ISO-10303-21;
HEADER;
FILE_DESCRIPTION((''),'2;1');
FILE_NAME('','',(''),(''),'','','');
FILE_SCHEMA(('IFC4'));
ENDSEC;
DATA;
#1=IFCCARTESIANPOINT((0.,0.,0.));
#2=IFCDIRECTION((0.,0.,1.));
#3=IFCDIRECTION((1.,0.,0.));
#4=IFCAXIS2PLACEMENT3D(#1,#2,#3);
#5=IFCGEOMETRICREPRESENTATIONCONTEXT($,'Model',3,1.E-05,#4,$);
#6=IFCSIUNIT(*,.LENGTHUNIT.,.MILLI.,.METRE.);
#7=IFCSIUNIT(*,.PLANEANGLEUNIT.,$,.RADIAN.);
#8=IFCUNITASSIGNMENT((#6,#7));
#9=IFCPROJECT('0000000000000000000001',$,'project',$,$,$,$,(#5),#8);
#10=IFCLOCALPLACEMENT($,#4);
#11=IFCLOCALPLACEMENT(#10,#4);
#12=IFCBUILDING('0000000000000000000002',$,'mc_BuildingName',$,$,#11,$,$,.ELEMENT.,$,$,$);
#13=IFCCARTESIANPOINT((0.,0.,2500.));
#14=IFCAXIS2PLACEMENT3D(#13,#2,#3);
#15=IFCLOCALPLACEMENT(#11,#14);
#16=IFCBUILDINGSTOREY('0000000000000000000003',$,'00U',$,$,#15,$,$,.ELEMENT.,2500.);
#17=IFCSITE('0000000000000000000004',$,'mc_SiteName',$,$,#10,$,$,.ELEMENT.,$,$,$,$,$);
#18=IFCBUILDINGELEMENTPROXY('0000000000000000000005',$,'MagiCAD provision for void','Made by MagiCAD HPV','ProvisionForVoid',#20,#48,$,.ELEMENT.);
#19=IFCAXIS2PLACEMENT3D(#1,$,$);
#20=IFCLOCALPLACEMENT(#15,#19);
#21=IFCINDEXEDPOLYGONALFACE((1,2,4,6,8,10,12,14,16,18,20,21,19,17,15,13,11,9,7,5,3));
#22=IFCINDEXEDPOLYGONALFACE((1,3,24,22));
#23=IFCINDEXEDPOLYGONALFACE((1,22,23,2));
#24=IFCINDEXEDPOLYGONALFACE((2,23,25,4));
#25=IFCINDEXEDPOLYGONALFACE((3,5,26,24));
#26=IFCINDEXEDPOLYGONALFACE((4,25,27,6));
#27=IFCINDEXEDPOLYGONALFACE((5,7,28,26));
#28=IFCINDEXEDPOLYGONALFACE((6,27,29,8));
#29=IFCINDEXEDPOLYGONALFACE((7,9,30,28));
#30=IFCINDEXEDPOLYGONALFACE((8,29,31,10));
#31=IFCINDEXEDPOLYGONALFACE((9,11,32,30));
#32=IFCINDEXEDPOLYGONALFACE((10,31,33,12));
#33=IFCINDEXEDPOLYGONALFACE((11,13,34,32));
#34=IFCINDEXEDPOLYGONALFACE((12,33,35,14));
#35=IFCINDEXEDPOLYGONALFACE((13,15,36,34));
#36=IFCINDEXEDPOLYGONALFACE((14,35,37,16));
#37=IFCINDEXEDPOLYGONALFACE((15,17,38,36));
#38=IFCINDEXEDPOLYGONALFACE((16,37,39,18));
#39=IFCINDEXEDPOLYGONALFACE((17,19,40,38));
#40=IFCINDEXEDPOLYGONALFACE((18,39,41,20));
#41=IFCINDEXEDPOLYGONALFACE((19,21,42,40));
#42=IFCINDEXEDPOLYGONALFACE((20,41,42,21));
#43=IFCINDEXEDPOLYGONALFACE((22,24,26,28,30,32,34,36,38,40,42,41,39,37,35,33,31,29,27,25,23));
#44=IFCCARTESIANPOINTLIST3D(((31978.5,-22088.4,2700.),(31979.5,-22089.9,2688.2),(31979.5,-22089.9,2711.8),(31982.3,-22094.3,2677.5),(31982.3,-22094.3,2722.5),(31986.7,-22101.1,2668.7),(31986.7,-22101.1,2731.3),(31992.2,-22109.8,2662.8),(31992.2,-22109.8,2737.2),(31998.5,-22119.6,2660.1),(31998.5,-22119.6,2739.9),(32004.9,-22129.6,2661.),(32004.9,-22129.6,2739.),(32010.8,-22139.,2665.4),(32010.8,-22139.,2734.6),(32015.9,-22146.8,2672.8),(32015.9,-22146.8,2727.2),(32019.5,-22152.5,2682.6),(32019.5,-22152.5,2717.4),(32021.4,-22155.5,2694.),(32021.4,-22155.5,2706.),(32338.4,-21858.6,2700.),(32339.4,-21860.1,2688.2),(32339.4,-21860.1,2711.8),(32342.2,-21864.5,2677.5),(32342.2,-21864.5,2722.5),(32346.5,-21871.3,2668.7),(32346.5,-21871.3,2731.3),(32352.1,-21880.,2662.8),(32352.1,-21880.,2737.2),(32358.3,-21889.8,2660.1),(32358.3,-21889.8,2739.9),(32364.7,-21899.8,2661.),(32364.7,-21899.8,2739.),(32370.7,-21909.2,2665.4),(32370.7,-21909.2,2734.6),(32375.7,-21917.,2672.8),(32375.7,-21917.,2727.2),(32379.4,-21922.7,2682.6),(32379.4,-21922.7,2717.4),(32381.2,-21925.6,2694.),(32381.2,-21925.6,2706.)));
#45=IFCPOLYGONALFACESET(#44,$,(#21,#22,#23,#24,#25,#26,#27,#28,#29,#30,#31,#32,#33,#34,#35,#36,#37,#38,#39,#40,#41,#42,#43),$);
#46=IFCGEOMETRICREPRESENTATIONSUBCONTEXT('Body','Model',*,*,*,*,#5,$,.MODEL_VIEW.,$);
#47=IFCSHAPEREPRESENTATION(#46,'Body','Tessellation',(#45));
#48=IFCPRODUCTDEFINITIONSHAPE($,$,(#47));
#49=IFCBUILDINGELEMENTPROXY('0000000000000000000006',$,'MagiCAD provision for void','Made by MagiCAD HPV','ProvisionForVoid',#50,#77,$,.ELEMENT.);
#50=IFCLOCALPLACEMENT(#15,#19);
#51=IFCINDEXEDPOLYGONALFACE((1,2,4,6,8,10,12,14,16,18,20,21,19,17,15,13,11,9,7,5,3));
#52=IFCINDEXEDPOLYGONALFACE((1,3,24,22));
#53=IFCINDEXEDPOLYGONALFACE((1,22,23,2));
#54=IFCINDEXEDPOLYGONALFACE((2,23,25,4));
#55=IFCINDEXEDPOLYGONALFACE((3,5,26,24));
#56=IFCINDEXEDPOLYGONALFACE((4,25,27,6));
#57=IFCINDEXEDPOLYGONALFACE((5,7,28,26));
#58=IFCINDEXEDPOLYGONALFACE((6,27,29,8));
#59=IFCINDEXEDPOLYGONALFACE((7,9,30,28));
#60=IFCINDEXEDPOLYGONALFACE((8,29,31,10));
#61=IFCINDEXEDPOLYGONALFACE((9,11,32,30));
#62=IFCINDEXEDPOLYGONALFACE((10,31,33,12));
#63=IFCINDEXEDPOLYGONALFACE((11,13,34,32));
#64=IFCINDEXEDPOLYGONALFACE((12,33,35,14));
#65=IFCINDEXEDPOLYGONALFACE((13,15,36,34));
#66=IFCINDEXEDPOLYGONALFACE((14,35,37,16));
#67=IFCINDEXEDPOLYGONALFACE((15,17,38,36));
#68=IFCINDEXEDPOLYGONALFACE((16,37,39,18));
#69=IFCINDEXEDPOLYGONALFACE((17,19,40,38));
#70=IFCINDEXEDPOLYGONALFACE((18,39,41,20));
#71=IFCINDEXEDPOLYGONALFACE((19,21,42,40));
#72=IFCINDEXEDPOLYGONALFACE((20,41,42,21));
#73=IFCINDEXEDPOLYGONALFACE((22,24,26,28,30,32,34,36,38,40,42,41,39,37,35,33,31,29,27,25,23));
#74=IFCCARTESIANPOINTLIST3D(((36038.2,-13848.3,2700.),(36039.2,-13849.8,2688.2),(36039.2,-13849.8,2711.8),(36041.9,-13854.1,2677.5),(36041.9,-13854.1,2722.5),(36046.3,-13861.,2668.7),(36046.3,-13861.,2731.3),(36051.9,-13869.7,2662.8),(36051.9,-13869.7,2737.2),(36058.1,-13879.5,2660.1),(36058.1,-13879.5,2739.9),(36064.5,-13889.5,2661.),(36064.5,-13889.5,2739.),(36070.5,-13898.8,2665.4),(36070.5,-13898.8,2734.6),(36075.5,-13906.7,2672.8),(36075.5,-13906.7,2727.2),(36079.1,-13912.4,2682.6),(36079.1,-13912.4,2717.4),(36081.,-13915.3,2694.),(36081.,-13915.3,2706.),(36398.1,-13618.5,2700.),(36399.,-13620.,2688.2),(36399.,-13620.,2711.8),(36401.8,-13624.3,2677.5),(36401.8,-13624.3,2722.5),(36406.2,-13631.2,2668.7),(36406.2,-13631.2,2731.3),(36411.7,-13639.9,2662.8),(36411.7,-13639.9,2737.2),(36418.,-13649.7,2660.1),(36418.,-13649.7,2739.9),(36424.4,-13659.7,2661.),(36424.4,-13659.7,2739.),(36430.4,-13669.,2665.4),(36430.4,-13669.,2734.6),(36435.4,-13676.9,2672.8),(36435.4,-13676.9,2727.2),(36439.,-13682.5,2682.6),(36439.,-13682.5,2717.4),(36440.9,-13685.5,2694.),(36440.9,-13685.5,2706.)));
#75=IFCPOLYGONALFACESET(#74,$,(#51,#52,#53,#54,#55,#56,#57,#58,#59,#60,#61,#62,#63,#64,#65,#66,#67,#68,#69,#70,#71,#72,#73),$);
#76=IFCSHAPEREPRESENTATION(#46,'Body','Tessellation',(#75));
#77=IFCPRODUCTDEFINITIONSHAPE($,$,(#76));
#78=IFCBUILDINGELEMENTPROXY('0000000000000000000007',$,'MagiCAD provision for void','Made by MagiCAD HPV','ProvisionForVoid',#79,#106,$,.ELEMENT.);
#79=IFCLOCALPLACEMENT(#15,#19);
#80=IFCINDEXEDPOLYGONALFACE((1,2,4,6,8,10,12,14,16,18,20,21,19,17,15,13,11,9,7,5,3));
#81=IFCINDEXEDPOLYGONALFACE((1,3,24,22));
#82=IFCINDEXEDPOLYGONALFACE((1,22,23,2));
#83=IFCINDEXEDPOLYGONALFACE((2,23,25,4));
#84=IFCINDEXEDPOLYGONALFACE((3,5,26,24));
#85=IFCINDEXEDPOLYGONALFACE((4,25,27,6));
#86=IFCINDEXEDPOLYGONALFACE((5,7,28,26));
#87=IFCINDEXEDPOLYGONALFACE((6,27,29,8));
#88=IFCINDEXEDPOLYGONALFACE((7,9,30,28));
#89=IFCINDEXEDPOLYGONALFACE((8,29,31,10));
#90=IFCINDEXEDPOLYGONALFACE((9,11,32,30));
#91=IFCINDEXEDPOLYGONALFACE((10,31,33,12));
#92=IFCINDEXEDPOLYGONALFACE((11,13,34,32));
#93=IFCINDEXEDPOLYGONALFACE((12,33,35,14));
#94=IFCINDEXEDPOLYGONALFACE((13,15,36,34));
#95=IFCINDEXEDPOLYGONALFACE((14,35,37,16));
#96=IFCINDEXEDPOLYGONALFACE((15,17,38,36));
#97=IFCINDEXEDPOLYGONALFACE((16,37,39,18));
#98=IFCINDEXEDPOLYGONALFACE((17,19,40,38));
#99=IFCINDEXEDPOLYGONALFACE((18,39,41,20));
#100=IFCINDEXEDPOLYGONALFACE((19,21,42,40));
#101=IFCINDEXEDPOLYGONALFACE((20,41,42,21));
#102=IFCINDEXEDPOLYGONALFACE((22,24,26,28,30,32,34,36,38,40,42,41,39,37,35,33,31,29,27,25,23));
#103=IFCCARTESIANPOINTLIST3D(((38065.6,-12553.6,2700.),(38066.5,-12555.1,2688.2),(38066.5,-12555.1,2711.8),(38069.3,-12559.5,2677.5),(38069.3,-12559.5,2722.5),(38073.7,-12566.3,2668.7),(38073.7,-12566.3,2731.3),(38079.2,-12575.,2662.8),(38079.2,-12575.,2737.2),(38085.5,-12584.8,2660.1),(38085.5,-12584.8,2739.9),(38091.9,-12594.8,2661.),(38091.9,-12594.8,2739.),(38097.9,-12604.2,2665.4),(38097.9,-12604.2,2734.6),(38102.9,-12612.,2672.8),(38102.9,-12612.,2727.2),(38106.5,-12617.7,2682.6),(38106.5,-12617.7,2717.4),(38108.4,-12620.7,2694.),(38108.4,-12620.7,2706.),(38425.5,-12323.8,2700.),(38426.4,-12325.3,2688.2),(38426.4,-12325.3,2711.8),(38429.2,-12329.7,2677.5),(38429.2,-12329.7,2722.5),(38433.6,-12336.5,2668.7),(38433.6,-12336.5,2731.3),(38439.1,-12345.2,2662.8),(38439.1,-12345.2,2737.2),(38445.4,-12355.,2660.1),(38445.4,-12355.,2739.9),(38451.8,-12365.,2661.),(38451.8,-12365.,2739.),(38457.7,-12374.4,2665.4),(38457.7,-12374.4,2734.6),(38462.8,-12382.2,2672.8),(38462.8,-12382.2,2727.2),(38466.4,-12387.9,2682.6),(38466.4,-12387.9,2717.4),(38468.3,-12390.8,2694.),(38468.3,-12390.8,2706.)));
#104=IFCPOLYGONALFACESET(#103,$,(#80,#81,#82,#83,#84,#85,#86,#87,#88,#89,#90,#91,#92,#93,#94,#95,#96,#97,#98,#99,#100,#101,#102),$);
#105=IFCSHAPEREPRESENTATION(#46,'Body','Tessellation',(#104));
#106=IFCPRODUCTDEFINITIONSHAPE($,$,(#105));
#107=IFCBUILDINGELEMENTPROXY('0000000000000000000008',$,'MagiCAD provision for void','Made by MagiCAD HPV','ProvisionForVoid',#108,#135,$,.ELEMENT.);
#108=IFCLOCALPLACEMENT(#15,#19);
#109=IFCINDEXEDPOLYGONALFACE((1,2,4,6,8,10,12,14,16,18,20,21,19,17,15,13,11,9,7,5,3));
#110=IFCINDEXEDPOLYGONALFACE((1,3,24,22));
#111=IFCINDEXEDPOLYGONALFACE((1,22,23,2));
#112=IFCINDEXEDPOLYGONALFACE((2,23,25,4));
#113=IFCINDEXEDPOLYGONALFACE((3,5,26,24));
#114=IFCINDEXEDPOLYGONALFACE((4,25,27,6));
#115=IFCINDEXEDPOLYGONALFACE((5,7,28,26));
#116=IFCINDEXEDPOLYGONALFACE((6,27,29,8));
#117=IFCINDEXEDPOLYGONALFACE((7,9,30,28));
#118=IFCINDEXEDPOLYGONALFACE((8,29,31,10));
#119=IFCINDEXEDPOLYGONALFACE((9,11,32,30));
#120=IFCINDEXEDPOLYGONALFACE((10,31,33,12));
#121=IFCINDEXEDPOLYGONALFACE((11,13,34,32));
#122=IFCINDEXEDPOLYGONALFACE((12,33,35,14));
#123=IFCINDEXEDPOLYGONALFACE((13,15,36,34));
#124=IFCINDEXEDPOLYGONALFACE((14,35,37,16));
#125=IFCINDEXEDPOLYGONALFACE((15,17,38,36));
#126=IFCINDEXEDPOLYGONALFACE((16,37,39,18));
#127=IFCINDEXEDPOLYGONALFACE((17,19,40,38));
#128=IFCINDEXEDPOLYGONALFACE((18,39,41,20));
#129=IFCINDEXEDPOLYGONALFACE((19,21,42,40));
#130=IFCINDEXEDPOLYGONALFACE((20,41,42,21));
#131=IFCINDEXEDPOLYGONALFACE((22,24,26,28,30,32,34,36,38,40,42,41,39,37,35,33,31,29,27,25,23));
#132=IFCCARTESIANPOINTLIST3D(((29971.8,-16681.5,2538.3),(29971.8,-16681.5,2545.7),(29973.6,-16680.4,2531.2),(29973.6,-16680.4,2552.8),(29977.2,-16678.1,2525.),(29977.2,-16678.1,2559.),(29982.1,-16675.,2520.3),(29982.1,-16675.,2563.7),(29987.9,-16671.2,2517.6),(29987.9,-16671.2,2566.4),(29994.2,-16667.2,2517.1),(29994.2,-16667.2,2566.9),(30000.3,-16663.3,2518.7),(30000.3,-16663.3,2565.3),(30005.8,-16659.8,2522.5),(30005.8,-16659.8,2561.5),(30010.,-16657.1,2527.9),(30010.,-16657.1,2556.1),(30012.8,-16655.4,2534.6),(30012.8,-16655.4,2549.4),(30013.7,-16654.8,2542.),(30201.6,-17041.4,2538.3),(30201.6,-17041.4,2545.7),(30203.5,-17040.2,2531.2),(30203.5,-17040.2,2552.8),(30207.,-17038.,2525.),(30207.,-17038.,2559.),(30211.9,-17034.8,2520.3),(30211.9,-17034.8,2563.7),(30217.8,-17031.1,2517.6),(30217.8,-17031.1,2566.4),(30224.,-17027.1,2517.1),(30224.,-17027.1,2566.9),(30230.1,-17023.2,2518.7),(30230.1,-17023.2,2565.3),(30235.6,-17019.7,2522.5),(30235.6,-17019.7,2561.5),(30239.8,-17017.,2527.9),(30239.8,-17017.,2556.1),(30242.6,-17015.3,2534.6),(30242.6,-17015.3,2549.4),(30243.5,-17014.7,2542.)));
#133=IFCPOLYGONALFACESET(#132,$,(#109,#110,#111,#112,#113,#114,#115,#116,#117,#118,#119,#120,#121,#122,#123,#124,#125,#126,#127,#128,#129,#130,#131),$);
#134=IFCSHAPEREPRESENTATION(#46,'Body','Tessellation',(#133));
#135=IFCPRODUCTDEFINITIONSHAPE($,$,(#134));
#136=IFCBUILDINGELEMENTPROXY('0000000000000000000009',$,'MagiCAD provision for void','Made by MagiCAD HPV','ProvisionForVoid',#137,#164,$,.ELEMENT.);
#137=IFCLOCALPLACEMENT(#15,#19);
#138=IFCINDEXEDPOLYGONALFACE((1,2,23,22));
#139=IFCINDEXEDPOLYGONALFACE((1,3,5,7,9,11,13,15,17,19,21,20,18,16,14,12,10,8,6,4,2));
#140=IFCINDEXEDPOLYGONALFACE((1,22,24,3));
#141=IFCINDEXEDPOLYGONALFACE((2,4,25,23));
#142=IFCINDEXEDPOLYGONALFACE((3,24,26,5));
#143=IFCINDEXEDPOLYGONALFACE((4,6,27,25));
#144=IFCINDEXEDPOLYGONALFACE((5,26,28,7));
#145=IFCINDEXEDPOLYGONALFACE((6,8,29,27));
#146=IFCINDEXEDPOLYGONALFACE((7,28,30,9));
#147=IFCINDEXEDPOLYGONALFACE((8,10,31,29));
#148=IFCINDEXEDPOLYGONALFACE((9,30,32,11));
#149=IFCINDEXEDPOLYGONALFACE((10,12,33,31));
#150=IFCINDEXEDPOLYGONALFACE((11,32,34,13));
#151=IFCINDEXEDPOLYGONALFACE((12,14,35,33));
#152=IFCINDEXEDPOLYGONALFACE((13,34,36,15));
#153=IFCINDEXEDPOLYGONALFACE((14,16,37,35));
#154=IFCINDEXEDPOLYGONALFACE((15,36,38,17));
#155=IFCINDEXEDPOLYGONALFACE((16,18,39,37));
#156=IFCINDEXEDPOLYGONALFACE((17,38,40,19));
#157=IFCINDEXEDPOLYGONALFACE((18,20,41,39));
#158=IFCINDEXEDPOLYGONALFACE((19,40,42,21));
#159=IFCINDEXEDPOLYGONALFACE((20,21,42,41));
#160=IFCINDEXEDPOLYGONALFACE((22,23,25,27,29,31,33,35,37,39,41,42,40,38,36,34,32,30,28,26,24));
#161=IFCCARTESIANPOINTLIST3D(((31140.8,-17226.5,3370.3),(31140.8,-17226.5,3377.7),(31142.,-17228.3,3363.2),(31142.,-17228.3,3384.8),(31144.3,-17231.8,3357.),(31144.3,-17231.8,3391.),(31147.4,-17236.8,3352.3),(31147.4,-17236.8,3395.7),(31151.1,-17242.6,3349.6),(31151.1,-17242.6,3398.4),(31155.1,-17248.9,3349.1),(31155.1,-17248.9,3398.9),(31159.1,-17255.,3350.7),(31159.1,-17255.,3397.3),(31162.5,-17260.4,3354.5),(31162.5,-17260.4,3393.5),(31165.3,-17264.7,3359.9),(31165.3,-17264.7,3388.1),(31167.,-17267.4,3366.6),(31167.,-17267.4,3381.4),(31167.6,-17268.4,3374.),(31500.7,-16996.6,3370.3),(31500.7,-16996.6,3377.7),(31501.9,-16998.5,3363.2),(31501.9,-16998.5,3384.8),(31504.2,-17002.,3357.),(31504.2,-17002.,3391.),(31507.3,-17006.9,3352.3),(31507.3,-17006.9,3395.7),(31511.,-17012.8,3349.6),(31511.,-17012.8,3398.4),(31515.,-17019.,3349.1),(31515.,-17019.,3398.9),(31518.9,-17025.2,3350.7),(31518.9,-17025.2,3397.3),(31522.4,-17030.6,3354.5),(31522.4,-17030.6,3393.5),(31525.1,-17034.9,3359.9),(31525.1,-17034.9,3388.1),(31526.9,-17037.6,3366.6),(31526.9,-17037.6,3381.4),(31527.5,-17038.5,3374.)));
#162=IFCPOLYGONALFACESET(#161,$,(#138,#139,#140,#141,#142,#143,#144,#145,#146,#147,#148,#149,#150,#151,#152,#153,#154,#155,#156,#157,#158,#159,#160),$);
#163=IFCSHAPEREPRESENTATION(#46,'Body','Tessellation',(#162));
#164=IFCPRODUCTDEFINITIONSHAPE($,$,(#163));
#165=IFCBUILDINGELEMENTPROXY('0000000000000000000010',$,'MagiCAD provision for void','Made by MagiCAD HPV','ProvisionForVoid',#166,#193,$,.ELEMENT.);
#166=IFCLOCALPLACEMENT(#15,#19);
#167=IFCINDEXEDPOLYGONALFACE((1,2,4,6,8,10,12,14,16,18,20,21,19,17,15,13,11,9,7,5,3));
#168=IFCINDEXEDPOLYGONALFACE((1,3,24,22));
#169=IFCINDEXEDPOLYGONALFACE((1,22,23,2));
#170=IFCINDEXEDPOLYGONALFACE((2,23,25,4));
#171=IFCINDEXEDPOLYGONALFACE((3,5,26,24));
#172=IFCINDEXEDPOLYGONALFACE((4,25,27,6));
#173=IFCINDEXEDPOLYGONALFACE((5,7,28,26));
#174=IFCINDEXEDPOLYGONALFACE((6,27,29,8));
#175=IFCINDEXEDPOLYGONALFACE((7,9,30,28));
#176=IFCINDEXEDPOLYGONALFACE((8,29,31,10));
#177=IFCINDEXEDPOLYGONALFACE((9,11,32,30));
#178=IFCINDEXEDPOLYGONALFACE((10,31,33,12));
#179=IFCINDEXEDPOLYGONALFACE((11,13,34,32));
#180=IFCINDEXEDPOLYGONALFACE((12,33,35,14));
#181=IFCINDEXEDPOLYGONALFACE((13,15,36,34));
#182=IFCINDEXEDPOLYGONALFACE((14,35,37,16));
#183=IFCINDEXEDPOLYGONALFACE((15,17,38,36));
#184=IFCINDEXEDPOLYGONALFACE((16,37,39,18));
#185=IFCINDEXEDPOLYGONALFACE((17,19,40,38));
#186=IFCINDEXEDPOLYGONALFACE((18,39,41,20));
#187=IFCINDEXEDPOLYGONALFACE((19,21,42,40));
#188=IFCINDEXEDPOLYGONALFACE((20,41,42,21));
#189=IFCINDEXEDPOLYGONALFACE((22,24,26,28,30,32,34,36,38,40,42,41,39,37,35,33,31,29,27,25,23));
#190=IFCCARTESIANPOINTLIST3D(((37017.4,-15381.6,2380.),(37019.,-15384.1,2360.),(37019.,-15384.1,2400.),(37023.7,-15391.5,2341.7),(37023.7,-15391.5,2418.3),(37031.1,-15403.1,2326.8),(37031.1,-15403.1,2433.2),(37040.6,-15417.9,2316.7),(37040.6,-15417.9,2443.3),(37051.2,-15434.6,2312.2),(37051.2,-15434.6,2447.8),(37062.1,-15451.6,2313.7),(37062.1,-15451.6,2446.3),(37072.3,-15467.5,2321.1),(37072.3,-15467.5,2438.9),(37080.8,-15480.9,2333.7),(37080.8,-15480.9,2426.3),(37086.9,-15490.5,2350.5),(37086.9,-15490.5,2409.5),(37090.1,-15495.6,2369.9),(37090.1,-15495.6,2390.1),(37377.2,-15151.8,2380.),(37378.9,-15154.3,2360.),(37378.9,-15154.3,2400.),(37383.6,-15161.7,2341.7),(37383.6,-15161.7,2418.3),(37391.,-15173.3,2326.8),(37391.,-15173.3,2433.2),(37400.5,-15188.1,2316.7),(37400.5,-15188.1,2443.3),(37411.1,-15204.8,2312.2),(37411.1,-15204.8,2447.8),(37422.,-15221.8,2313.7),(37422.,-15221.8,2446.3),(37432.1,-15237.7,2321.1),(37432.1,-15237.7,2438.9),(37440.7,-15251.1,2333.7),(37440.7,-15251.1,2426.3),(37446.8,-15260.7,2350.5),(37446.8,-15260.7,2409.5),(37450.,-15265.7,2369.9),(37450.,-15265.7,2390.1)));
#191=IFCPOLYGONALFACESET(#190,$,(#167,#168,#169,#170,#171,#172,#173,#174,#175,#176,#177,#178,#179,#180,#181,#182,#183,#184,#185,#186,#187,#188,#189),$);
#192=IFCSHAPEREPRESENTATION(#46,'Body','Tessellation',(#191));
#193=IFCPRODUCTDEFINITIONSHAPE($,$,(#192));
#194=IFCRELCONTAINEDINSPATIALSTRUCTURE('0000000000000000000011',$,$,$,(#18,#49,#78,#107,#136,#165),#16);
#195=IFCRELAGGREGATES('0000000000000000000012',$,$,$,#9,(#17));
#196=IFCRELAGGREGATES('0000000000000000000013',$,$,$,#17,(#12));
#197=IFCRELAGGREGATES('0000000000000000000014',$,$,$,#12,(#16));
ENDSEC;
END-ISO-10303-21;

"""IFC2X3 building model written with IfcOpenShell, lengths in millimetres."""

from ifc_helpers import new_model, si_unit, frame, origin_with_axes, origin_2d_with_axis, place, context, subcontext, project, spatial, circle, extrude, source, transform, mapped, element, save


model = new_model("IFC2X3")

# Units and contexts
model_context = context("Model", 3, precision=1e-05, world=origin_with_axes())
body_context = subcontext(model_context, "Body", "Model", "MODEL_VIEW")
ifc_project = project(units=[si_unit("LENGTHUNIT", "METRE", prefix="MILLI"), si_unit("PLANEANGLEUNIT", "RADIAN")], contexts=[model_context])

# Site, building, storey
site_placement = place(None, origin_with_axes())
site = spatial("IfcSite", under=ifc_project, at=site_placement, Name="mc_SiteName", CompositionType="ELEMENT")
building_placement = place(site_placement, origin_with_axes())
building = spatial("IfcBuilding", under=site, at=building_placement, Name="mc_BuildingName", CompositionType="ELEMENT")
storey_placement = place(building_placement, frame((0.0, 0.0, 2500.0), z_axis=(0.0, 0.0, 1.0), x_axis=(1.0, 0.0, 0.0)))
storey = spatial("IfcBuildingStorey", under=building, at=storey_placement, Name="00U", CompositionType="ELEMENT", Elevation=2500.0)

# Building element proxies
shared_shape_1 = source(origin_with_axes(), body_context, "Body", "SweptSolid", [
    extrude(circle(Radius=40.0, at=origin_2d_with_axis()), frame((0.0, 0.0, 0.0), z_axis=(1.0, 0.0, 0.0), x_axis=(0.0, 1.0, 0.0)), (0.0, 0.0, 1.0), 427.0),
])
proxy_1_placement = place(storey_placement, frame((32000.1, -22122.1, 2700.0), z_axis=(0.0, 0.0, 1.0), x_axis=(0.842809, 0.538213, 0.0)))
element("IfcBuildingElementProxy", 1, at=proxy_1_placement, inside=storey, Name="MagiCAD provision for void", Description="Made by MagiCAD HPV", ObjectType="ProvisionForVoid", CompositionType="ELEMENT", context=body_context, shape_type="MappedRepresentation", body=[
    mapped(shared_shape_1, transform((0.0, 0.0, 0.0), scale=1.0)),
])
shared_shape_2 = source(origin_with_axes(), body_context, "Body", "SweptSolid", [
    extrude(circle(Radius=40.0, at=origin_2d_with_axis()), frame((0.0, 0.0, 0.0), z_axis=(1.0, 0.0, 0.0), x_axis=(0.0, 1.0, 0.0)), (0.0, 0.0, 1.0), 427.0),
])
proxy_2_placement = place(storey_placement, frame((36059.7, -13882.0, 2700.0), z_axis=(0.0, 0.0, 1.0), x_axis=(0.842809, 0.538213, 0.0)))
element("IfcBuildingElementProxy", 2, at=proxy_2_placement, inside=storey, Name="MagiCAD provision for void", Description="Made by MagiCAD HPV", ObjectType="ProvisionForVoid", CompositionType="ELEMENT", context=body_context, shape_type="MappedRepresentation", body=[
    mapped(shared_shape_2, transform((0.0, 0.0, 0.0), scale=1.0)),
])
shared_shape_3 = source(origin_with_axes(), body_context, "Body", "SweptSolid", [
    extrude(circle(Radius=40.0, at=origin_2d_with_axis()), frame((0.0, 0.0, 0.0), z_axis=(1.0, 0.0, 0.0), x_axis=(0.0, 1.0, 0.0)), (0.0, 0.0, 1.0), 427.0),
])
proxy_3_placement = place(storey_placement, frame((38087.1, -12587.3, 2700.0), z_axis=(0.0, 0.0, 1.0), x_axis=(0.842809, 0.538213, 0.0)))
element("IfcBuildingElementProxy", 3, at=proxy_3_placement, inside=storey, Name="MagiCAD provision for void", Description="Made by MagiCAD HPV", ObjectType="ProvisionForVoid", CompositionType="ELEMENT", context=body_context, shape_type="MappedRepresentation", body=[
    mapped(shared_shape_3, transform((0.0, 0.0, 0.0), scale=1.0)),
])
shared_shape_4 = source(origin_with_axes(), body_context, "Body", "SweptSolid", [
    extrude(circle(Radius=25.0, at=origin_2d_with_axis()), frame((0.0, 0.0, 0.0), z_axis=(1.0, 0.0, 0.0), x_axis=(0.0, 1.0, 0.0)), (0.0, 0.0, 1.0), 427.0),
])
proxy_4_placement = place(storey_placement, frame((29992.6, -16668.2, 2542.0), z_axis=(0.0, 0.0, 1.0), x_axis=(0.538213, -0.842809, 0.0)))
element("IfcBuildingElementProxy", 4, at=proxy_4_placement, inside=storey, Name="MagiCAD provision for void", Description="Made by MagiCAD HPV", ObjectType="ProvisionForVoid", CompositionType="ELEMENT", context=body_context, shape_type="MappedRepresentation", body=[
    mapped(shared_shape_4, transform((0.0, 0.0, 0.0), scale=1.0)),
])
shared_shape_5 = source(origin_with_axes(), body_context, "Body", "SweptSolid", [
    extrude(circle(Radius=25.0, at=origin_2d_with_axis()), frame((0.0, 0.0, 0.0), z_axis=(1.0, 0.0, 0.0), x_axis=(0.0, 1.0, 0.0)), (0.0, 0.0, 1.0), 427.0),
])
proxy_5_placement = place(storey_placement, frame((31514.0, -17017.5, 3374.0), z_axis=(0.0, 0.0, 1.0), x_axis=(-0.842809, -0.538213, 0.0)))
element("IfcBuildingElementProxy", 5, at=proxy_5_placement, inside=storey, Name="MagiCAD provision for void", Description="Made by MagiCAD HPV", ObjectType="ProvisionForVoid", CompositionType="ELEMENT", context=body_context, shape_type="MappedRepresentation", body=[
    mapped(shared_shape_5, transform((0.0, 0.0, 0.0), scale=1.0)),
])
shared_shape_6 = source(origin_with_axes(), body_context, "Body", "SweptSolid", [
    extrude(circle(Radius=68.0, at=origin_2d_with_axis()), frame((0.0, 0.0, 0.0), z_axis=(1.0, 0.0, 0.0), x_axis=(0.0, 1.0, 0.0)), (0.0, 0.0, 1.0), 427.0),
])
proxy_6_placement = place(storey_placement, frame((37054.0, -15438.9, 2380.0), z_axis=(0.0, 0.0, 1.0), x_axis=(0.842809, 0.538213, 0.0)))
element("IfcBuildingElementProxy", 6, at=proxy_6_placement, inside=storey, Name="MagiCAD provision for void", Description="Made by MagiCAD HPV", ObjectType="ProvisionForVoid", CompositionType="ELEMENT", context=body_context, shape_type="MappedRepresentation", body=[
    mapped(shared_shape_6, transform((0.0, 0.0, 0.0), scale=1.0)),
])

save(model, "model.ifc")
